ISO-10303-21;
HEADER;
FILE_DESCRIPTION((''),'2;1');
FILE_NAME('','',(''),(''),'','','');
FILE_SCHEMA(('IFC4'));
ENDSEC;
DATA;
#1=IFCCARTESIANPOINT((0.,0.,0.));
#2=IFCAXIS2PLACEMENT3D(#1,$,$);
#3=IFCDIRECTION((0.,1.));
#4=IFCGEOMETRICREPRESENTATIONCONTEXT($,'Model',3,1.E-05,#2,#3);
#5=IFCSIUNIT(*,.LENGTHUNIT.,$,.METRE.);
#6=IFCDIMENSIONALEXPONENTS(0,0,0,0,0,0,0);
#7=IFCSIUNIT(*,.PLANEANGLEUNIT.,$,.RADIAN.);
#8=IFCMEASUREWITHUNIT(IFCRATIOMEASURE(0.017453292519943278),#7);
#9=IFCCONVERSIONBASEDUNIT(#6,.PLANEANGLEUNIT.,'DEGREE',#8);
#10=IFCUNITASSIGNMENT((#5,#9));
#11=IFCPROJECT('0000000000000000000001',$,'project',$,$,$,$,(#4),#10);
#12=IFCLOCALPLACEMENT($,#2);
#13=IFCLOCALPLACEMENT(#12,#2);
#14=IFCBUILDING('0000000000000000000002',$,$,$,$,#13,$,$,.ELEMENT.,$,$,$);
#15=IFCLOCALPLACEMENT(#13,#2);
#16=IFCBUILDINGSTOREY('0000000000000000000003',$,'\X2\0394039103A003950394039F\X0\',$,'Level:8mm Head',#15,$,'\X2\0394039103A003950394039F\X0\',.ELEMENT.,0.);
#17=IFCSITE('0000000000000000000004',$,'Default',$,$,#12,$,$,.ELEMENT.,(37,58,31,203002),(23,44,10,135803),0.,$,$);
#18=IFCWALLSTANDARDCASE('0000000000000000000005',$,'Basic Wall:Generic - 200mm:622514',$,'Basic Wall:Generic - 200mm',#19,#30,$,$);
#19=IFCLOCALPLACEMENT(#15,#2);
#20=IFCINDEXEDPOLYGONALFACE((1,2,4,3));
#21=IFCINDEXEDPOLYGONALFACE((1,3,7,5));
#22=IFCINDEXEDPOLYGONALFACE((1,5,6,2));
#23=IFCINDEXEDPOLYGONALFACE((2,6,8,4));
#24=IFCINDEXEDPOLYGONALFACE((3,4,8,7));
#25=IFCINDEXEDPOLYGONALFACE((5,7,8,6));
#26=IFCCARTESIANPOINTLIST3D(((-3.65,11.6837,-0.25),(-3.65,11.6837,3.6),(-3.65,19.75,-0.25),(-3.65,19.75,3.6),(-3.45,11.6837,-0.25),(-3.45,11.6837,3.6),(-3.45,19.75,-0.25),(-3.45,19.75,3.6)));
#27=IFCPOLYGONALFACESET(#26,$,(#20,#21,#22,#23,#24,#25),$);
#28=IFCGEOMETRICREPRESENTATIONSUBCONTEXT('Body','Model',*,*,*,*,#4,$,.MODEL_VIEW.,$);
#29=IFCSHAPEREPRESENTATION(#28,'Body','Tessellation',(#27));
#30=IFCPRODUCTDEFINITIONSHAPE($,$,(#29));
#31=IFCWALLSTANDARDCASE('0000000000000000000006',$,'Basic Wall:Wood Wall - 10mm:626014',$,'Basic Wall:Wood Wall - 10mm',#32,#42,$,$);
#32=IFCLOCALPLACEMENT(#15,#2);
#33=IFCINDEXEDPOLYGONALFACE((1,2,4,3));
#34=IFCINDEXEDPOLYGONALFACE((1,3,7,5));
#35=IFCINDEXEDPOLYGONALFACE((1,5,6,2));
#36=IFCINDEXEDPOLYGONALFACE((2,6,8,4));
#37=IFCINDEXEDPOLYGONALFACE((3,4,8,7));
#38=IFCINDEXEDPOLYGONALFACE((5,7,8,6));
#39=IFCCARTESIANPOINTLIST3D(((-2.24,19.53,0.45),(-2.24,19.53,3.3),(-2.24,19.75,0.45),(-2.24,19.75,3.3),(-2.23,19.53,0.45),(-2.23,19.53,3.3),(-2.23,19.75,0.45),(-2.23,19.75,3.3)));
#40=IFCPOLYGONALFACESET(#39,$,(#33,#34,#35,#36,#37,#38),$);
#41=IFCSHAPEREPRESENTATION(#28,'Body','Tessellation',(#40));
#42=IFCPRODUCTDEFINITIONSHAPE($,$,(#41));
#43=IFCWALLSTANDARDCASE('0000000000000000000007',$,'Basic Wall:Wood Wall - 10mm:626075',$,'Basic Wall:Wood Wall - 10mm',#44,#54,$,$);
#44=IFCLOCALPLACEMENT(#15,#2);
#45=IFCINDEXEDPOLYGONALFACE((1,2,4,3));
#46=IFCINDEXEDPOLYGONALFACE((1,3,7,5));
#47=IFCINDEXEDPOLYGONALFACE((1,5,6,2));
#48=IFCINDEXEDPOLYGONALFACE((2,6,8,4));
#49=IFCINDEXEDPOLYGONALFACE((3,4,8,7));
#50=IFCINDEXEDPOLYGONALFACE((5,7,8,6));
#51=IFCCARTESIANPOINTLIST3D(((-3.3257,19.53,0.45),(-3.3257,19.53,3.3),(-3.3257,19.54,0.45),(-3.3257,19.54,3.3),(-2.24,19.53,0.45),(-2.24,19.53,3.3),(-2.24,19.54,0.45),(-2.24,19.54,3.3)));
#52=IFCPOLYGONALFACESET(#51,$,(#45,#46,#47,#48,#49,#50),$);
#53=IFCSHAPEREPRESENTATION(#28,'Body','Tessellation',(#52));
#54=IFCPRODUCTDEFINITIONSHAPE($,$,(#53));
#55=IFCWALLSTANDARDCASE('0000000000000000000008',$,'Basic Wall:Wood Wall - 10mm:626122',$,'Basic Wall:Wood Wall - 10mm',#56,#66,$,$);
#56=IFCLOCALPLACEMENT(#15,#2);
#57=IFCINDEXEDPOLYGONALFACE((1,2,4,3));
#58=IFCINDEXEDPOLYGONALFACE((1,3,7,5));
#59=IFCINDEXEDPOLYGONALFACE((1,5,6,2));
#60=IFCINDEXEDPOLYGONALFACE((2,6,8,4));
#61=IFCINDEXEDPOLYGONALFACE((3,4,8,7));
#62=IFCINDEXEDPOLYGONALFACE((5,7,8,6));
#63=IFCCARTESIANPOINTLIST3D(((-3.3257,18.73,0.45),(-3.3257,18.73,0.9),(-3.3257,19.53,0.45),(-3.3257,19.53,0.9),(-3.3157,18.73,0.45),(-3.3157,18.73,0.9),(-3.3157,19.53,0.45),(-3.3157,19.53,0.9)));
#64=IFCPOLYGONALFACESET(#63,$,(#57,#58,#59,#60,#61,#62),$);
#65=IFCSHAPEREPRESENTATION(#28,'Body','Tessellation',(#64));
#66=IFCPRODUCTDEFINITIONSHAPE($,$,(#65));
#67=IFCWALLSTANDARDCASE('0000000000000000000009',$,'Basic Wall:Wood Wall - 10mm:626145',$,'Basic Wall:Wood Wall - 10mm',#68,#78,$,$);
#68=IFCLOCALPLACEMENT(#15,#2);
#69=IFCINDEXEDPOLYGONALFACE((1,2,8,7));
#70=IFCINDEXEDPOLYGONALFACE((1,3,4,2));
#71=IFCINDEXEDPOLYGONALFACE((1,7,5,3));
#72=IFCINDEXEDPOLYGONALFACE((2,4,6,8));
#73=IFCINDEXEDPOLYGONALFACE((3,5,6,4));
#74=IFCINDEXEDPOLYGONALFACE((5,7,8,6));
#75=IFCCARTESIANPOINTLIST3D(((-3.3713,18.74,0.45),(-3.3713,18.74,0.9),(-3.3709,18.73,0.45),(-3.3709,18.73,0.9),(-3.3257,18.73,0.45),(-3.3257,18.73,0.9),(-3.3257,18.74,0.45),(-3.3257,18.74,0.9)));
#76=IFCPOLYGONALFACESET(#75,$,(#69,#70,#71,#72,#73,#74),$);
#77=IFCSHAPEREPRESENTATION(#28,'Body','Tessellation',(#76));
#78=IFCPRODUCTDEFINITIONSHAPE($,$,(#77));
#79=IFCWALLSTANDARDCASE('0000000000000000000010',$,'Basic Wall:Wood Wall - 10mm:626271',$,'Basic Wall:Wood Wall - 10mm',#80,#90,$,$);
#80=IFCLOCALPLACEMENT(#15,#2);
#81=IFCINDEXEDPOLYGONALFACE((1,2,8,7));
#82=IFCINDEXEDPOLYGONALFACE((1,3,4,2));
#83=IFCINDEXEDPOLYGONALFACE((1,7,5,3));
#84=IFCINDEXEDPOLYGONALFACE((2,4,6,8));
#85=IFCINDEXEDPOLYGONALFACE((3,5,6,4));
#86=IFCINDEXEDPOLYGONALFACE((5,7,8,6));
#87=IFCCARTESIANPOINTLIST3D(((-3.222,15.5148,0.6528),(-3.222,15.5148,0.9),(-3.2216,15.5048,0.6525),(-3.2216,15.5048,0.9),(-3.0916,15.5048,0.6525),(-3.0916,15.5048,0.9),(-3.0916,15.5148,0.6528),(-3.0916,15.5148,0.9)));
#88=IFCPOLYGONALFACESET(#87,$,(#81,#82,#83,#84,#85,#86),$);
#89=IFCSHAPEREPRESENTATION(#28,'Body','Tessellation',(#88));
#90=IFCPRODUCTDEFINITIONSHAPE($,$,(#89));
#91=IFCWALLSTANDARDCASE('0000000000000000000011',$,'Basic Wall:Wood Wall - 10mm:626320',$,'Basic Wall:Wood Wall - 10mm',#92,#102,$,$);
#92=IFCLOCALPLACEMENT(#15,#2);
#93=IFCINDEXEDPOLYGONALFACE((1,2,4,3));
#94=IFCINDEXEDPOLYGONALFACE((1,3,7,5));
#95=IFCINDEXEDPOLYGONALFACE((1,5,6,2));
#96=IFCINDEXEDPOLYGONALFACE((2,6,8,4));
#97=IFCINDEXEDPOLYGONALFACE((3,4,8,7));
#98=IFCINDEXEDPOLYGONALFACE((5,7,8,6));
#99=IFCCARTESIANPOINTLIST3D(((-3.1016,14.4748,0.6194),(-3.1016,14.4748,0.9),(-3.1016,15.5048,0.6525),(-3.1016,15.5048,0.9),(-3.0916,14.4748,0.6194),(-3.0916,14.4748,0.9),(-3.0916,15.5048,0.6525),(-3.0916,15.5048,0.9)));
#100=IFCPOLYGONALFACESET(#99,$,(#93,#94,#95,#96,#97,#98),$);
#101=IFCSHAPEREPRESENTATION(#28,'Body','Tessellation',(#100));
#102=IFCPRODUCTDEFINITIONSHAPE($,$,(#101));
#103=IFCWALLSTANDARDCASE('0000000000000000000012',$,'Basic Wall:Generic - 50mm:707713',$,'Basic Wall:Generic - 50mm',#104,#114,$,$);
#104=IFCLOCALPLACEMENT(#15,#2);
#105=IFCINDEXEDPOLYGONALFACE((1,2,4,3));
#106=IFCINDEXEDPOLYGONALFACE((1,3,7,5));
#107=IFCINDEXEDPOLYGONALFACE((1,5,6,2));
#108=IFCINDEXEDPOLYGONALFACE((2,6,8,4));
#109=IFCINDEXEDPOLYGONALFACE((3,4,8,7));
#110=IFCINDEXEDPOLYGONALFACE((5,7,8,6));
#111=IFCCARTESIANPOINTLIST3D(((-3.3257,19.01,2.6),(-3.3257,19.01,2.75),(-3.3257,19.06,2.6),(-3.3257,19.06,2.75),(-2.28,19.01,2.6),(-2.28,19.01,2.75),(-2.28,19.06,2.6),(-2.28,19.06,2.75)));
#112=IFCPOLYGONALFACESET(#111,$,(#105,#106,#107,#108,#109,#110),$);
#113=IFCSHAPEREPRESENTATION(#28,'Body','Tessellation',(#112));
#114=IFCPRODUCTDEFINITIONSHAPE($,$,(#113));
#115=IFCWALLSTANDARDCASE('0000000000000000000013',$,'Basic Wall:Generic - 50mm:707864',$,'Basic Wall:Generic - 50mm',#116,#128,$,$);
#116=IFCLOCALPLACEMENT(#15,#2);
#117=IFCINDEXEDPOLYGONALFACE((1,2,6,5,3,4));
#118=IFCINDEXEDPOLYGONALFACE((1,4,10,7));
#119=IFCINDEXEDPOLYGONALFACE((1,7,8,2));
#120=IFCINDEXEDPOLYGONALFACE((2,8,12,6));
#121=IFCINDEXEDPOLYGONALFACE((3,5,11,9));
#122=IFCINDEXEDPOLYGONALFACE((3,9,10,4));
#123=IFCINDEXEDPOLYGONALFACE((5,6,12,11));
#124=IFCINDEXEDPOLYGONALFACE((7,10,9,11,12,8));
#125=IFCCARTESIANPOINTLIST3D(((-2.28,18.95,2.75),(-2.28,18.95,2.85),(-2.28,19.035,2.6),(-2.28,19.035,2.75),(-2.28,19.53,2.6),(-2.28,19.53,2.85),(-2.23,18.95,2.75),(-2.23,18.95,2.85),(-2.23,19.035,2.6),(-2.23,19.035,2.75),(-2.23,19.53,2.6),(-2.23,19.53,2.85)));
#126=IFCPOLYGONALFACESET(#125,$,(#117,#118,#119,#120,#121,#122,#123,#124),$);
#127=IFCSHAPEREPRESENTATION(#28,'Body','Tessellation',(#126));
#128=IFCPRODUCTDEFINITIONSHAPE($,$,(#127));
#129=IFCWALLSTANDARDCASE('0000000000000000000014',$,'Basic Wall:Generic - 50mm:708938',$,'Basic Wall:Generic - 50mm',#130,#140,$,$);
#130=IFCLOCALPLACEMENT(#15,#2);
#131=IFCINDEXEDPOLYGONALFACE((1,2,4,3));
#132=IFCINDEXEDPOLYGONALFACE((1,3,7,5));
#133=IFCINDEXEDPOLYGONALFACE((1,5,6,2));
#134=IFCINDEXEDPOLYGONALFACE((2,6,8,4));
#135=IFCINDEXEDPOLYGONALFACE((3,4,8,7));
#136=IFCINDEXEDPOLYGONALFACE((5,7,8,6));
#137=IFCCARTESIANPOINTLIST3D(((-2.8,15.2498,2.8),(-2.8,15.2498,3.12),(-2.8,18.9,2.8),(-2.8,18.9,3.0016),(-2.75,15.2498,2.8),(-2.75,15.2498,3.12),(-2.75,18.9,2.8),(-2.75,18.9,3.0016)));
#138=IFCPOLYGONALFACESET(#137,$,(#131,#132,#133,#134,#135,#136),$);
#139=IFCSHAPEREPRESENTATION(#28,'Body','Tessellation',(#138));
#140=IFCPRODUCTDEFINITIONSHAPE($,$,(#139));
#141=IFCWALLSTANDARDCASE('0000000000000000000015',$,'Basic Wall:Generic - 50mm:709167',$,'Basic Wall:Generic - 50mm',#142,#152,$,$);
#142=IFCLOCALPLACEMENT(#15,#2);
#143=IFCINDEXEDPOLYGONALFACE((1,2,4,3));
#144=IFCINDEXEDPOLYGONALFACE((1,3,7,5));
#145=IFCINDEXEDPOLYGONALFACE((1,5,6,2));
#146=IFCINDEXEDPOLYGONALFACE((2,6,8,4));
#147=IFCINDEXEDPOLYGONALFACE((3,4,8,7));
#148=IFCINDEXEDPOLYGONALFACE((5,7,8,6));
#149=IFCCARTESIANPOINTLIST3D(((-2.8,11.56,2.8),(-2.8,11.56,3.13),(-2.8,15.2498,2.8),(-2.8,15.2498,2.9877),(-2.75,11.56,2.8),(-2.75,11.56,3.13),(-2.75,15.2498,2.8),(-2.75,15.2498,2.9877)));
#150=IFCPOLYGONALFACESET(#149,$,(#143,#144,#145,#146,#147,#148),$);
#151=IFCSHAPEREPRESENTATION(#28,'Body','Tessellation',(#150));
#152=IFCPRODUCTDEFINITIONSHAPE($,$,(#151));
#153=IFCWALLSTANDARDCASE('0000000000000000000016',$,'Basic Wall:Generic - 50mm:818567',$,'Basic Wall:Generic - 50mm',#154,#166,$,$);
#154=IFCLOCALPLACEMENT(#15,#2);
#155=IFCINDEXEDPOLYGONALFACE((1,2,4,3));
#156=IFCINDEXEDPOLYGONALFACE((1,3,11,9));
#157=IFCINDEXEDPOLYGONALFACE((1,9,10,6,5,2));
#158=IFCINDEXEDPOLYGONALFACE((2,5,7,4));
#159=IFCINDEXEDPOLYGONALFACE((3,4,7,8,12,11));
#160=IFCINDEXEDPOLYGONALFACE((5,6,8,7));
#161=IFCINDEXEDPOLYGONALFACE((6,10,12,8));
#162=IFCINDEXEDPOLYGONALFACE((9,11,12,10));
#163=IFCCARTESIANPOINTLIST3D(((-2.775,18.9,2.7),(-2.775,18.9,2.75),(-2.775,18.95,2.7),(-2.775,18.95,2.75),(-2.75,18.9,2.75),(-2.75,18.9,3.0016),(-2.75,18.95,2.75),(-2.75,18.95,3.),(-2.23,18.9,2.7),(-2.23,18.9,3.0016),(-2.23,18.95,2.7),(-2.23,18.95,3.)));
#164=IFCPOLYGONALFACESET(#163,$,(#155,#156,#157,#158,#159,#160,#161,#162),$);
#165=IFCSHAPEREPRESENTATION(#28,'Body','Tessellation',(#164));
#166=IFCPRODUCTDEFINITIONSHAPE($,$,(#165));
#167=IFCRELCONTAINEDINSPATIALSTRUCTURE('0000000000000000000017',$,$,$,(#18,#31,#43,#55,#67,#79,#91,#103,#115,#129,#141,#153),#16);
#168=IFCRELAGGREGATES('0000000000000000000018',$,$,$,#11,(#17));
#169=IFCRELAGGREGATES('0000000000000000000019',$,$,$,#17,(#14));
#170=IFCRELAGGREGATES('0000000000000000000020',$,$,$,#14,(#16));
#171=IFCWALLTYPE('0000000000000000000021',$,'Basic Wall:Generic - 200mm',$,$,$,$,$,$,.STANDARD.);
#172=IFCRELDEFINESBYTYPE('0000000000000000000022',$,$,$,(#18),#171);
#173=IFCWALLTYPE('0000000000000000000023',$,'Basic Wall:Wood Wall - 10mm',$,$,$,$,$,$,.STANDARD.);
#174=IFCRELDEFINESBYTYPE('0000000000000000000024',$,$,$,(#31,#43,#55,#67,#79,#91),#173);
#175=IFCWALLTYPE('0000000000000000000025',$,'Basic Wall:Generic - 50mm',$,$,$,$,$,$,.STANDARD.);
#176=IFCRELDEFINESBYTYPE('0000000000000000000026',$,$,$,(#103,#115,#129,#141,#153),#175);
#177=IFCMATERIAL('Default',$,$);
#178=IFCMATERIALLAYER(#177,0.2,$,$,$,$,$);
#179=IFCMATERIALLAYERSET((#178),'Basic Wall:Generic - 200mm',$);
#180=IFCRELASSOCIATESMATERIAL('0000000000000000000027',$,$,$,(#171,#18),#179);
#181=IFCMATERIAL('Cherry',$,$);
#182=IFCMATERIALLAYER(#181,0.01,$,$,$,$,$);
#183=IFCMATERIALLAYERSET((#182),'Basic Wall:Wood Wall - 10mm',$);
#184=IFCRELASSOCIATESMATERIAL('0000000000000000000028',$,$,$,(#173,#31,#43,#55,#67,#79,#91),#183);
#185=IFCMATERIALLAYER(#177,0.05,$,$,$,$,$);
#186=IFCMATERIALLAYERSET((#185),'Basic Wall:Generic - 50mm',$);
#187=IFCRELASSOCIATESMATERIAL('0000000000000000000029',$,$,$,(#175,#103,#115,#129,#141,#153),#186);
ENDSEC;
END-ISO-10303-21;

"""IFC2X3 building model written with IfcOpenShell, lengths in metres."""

from ifc_helpers import new_model, entity, si_unit, converted_unit, direction, frame, frame_2d, origin, place, context, subcontext, project, spatial, polyline, rectangle, outline, extrude, clip, bounded_halfspace, material, layer, layer_set, layer_usage, type_object, element, save


model = new_model("IFC2X3")

# Units and contexts
model_context = context("Model", 3, precision=1e-05, world=origin(), true_north=direction((0.0, 1.0)))
body_context = subcontext(model_context, "Body", "Model", "MODEL_VIEW")
ifc_project = project(units=[si_unit("LENGTHUNIT", "METRE"), converted_unit("PLANEANGLEUNIT", "DEGREE", entity("IfcRatioMeasure", 0.017453292519943278), si_unit("PLANEANGLEUNIT", "RADIAN"), dimensions=[0, 0, 0, 0, 0, 0, 0])], contexts=[model_context])

# Site, building, storey
site_placement = place(None, origin())
site = spatial("IfcSite", under=ifc_project, at=site_placement, Name="Default", CompositionType="ELEMENT", RefLatitude=(37, 58, 31, 203002), RefLongitude=(23, 44, 10, 135803), RefElevation=0.0)
building_placement = place(site_placement, origin())
building = spatial("IfcBuilding", under=site, at=building_placement, CompositionType="ELEMENT")
storey_placement = place(building_placement, origin())
storey = spatial("IfcBuildingStorey", under=building, at=storey_placement, Name="ΔΑΠΕΔΟ", ObjectType="Level:8mm Head", LongName="ΔΑΠΕΔΟ", CompositionType="ELEMENT", Elevation=0.0)

# Walls
ifc_material_1 = material(Name="Default")
ifc_layer_1 = layer(ifc_material_1, 0.2)
ifc_layer_set_1 = layer_set([ifc_layer_1], Name="Basic Wall:Generic - 200mm")
ifc_layer_usage_1 = layer_usage(ifc_layer_set_1, "AXIS2", "NEGATIVE", 0.1)
wall_type_1 = type_object("IfcWallType", Name="Basic Wall:Generic - 200mm", PredefinedType="STANDARD", material=ifc_layer_set_1)
wall_1_placement = place(storey_placement, frame((-3.55, 19.75, -0.25), z_axis=(0.0, 0.0, 1.0), x_axis=(0.0, -1.0, 0.0)))
element("IfcWallStandardCase", 1, at=wall_1_placement, inside=storey, type_object=wall_type_1, material=ifc_layer_usage_1, Name="Basic Wall:Generic - 200mm:622514", ObjectType="Basic Wall:Generic - 200mm", context=body_context, shape_type="SweptSolid", body=[
    extrude(rectangle(XDim=8.0663, YDim=0.2, at=frame_2d((4.0331, 0.0), x_axis=(-1.0, 0.0))), origin(), (0.0, 0.0, 1.0), 3.85),
])
ifc_material_2 = material(Name="Cherry")
ifc_layer_2 = layer(ifc_material_2, 0.01)
ifc_layer_set_2 = layer_set([ifc_layer_2], Name="Basic Wall:Wood Wall - 10mm")
ifc_layer_usage_2 = layer_usage(ifc_layer_set_2, "AXIS2", "NEGATIVE", 0.005)
wall_type_2 = type_object("IfcWallType", Name="Basic Wall:Wood Wall - 10mm", PredefinedType="STANDARD", material=ifc_layer_set_2)
wall_2_placement = place(storey_placement, frame((-2.235, 19.75, 0.45), z_axis=(0.0, 0.0, 1.0), x_axis=(0.0, -1.0, 0.0)))
element("IfcWallStandardCase", 2, at=wall_2_placement, inside=storey, type_object=wall_type_2, material=ifc_layer_usage_2, Name="Basic Wall:Wood Wall - 10mm:626014", ObjectType="Basic Wall:Wood Wall - 10mm", context=body_context, shape_type="SweptSolid", body=[
    extrude(rectangle(XDim=0.22, YDim=0.01, at=frame_2d((0.11, 0.0), x_axis=(-1.0, 0.0))), origin(), (0.0, 0.0, 1.0), 2.85),
])
wall_3_placement = place(storey_placement, frame((-2.24, 19.535, 0.45), z_axis=(0.0, 0.0, 1.0), x_axis=(-1.0, 0.0, 0.0)))
element("IfcWallStandardCase", 3, at=wall_3_placement, inside=storey, type_object=wall_type_2, material=ifc_layer_usage_2, Name="Basic Wall:Wood Wall - 10mm:626075", ObjectType="Basic Wall:Wood Wall - 10mm", context=body_context, shape_type="SweptSolid", body=[
    extrude(rectangle(XDim=1.0857, YDim=0.01, at=frame_2d((0.5428, 0.0), x_axis=(-1.0, 0.0))), origin(), (0.0, 0.0, 1.0), 2.85),
])
wall_4_placement = place(storey_placement, frame((-3.3207, 19.53, 0.45), z_axis=(0.0, 0.0, 1.0), x_axis=(0.0, -1.0, 0.0)))
element("IfcWallStandardCase", 4, at=wall_4_placement, inside=storey, type_object=wall_type_2, material=ifc_layer_usage_2, Name="Basic Wall:Wood Wall - 10mm:626122", ObjectType="Basic Wall:Wood Wall - 10mm", context=body_context, shape_type="SweptSolid", body=[
    extrude(rectangle(XDim=0.8, YDim=0.01, at=frame_2d((0.4, 0.0), x_axis=(-1.0, 0.0))), origin(), (0.0, 0.0, 1.0), 0.45),
])
wall_5_placement = place(storey_placement, frame((-3.3257, 18.735, 0.45), z_axis=(0.0, 0.0, 1.0), x_axis=(-1.0, 0.0, 0.0)))
element("IfcWallStandardCase", 5, at=wall_5_placement, inside=storey, type_object=wall_type_2, material=ifc_layer_usage_2, Name="Basic Wall:Wood Wall - 10mm:626145", ObjectType="Basic Wall:Wood Wall - 10mm", context=body_context, shape_type="SweptSolid", body=[
    extrude(outline(polyline([(0.0457, -0.005), (0.0452, 0.005), (0.0, 0.005), (0.0, -0.005), (0.0457, -0.005)])), origin(), (0.0, 0.0, 1.0), 0.45),
])
ifc_layer_usage_3 = layer_usage(ifc_layer_set_2, "AXIS2", "POSITIVE", -0.005)
wall_6_placement = place(storey_placement, frame((-3.222, 15.5098, 0.6525)))
element("IfcWallStandardCase", 6, at=wall_6_placement, inside=storey, type_object=wall_type_2, material=ifc_layer_usage_3, Name="Basic Wall:Wood Wall - 10mm:626271", ObjectType="Basic Wall:Wood Wall - 10mm", context=body_context, shape_type="Clipping", body=[
    clip(extrude(outline(polyline([(0.0004, -0.005), (0.1204, -0.005), (0.1304, -0.005), (0.1304, 0.005), (0.0, 0.005), (0.0004, -0.005)])), origin(), (0.0, 0.0, 1.0), 0.2475), bounded_halfspace(frame((0.1304, -0.005, 0.0), z_axis=(0.0, -0.032108, 0.999484), x_axis=(1.0, 0.0, 0.0)), True, frame((0.1304, -0.005, 0.0)), polyline([(0.0, 0.0), (0.0, 0.01), (-0.1304, 0.01), (-0.13, 0.0), (-0.01, 0.0), (0.0, 0.0)]))),
])
wall_7_placement = place(storey_placement, frame((-3.0966, 15.5048, 0.6194), z_axis=(0.0, 0.0, 1.0), x_axis=(0.0, -1.0, 0.0)))
element("IfcWallStandardCase", 7, at=wall_7_placement, inside=storey, type_object=wall_type_2, material=ifc_layer_usage_3, Name="Basic Wall:Wood Wall - 10mm:626320", ObjectType="Basic Wall:Wood Wall - 10mm", context=body_context, shape_type="Clipping", body=[
    clip(extrude(rectangle(XDim=1.03, YDim=0.01, at=frame_2d((0.515, 0.0), x_axis=(-1.0, 0.0))), origin(), (0.0, 0.0, 1.0), 0.2806), bounded_halfspace(frame((1.03, -0.005, 0.0), z_axis=(0.032108, 0.0, 0.999484), x_axis=(0.0, 1.0, 0.0)), True, frame((1.03, -0.005, 0.0)), polyline([(0.0, 0.0), (0.0, 0.01), (-1.03, 0.01), (-1.03, 0.0), (-0.01, 0.0), (0.0, 0.0)]))),
])
ifc_layer_3 = layer(ifc_material_1, 0.05)
ifc_layer_set_3 = layer_set([ifc_layer_3], Name="Basic Wall:Generic - 50mm")
ifc_layer_usage_4 = layer_usage(ifc_layer_set_3, "AXIS2", "NEGATIVE", 0.025)
wall_type_3 = type_object("IfcWallType", Name="Basic Wall:Generic - 50mm", PredefinedType="STANDARD", material=ifc_layer_set_3)
wall_8_placement = place(storey_placement, frame((-3.3257, 19.035, 2.6)))
element("IfcWallStandardCase", 8, at=wall_8_placement, inside=storey, type_object=wall_type_3, material=ifc_layer_usage_4, Name="Basic Wall:Generic - 50mm:707713", ObjectType="Basic Wall:Generic - 50mm", context=body_context, shape_type="SweptSolid", body=[
    extrude(rectangle(XDim=1.0457, YDim=0.05, at=frame_2d((0.5228, 0.0), x_axis=(-1.0, 0.0))), origin(), (0.0, 0.0, 1.0), 0.15),
])

# Wall, opening
wall_9_placement = place(storey_placement, frame((-2.255, 18.95, 2.6), z_axis=(0.0, 0.0, 1.0), x_axis=(0.0, 1.0, 0.0)))
wall_9 = element("IfcWallStandardCase", 9, at=wall_9_placement, inside=storey, type_object=wall_type_3, material=ifc_layer_usage_4, Name="Basic Wall:Generic - 50mm:707864", ObjectType="Basic Wall:Generic - 50mm", context=body_context, shape_type="SweptSolid", body=[
    extrude(rectangle(XDim=0.58, YDim=0.05, at=frame_2d((0.29, 0.0), x_axis=(-1.0, 0.0))), origin(), (0.0, 0.0, 1.0), 0.25),
])
opening_placement = place(wall_9_placement, origin())
element("IfcOpeningElement", 10, at=opening_placement, cuts=wall_9, ObjectType="Opening", context=body_context, shape_type="SweptSolid", body=[
    extrude(rectangle(XDim=0.15, YDim=0.11, at=frame_2d((0.0, 0.0), x_axis=(1.0, 0.0))), frame((0.03, 0.025, 0.075), z_axis=(0.0, -1.0, 0.0), x_axis=(0.0, 0.0, 1.0)), (0.0, 0.0, 1.0), 0.05),
])

# Walls
wall_10_placement = place(storey_placement, frame((-2.775, 18.9, 2.8), z_axis=(0.0, 0.0, 1.0), x_axis=(0.0, -1.0, 0.0)))
element("IfcWallStandardCase", 11, at=wall_10_placement, inside=storey, type_object=wall_type_3, material=ifc_layer_usage_4, Name="Basic Wall:Generic - 50mm:708938", ObjectType="Basic Wall:Generic - 50mm", context=body_context, shape_type="Clipping", body=[
    clip(extrude(rectangle(XDim=3.6502, YDim=0.05, at=frame_2d((1.8251, 0.0), x_axis=(-1.0, 0.0))), origin(), (0.0, 0.0, 1.0), 0.32), bounded_halfspace(frame((0.0, -0.025, 0.2016), z_axis=(0.032414, 0.0, -0.999475), x_axis=(-0.999475, 0.0, -0.032414)), True, frame((0.0, -0.025, 0.2016)), polyline([(0.0, 0.0), (3.6502, 0.0), (3.6502, 0.05), (0.0, 0.05), (0.0, 0.025), (0.0, 0.0)]))),
])
wall_11_placement = place(storey_placement, frame((-2.775, 15.2498, 2.8), z_axis=(0.0, 0.0, 1.0), x_axis=(0.0, -1.0, 0.0)))
element("IfcWallStandardCase", 12, at=wall_11_placement, inside=storey, type_object=wall_type_3, material=ifc_layer_usage_4, Name="Basic Wall:Generic - 50mm:709167", ObjectType="Basic Wall:Generic - 50mm", context=body_context, shape_type="Clipping", body=[
    clip(extrude(rectangle(XDim=3.6898, YDim=0.05, at=frame_2d((1.8449, 0.0), x_axis=(-1.0, 0.0))), origin(), (0.0, 0.0, 1.0), 0.33), bounded_halfspace(frame((0.0, -0.025, 0.1877), z_axis=(0.038534, 0.0, -0.999257), x_axis=(-0.999257, 0.0, -0.038534)), True, frame((0.0, -0.025, 0.1877)), polyline([(0.0, 0.0), (3.6898, 0.0), (3.6898, 0.05), (0.0, 0.05), (0.0, 0.0)]))),
])
wall_12_placement = place(storey_placement, frame((-2.775, 18.925, 2.7)))
element("IfcWallStandardCase", 13, at=wall_12_placement, inside=storey, type_object=wall_type_3, material=ifc_layer_usage_4, Name="Basic Wall:Generic - 50mm:818567", ObjectType="Basic Wall:Generic - 50mm", context=body_context, shape_type="Clipping", body=[
    clip(clip(extrude(rectangle(XDim=0.545, YDim=0.05, at=frame_2d((0.2725, 0.0), x_axis=(-1.0, 0.0))), origin(), (0.0, 0.0, 1.0), 0.3016), bounded_halfspace(frame((0.025, -0.025, 0.3016), z_axis=(0.0, -0.032414, -0.999475), x_axis=(0.0, 0.999475, -0.032414)), True, frame((0.025, -0.025, 0.3016)), polyline([(0.0, 0.0), (0.52, 0.0), (0.52, 0.05), (0.0, 0.05), (0.0, 0.0)]))), bounded_halfspace(frame((0.025, -0.025, 0.05), z_axis=(0.0, 0.0, -1.0), x_axis=(0.0, -1.0, 0.0)), True, frame((0.025, -0.025, 0.05), z_axis=(0.0, 0.0, -1.0), x_axis=(0.0, -1.0, 0.0)), polyline([(0.0, 0.0), (0.0, 0.025), (-0.05, 0.025), (-0.05, 0.0), (0.0, 0.0)]))),
])

save(model, "model.ifc")
